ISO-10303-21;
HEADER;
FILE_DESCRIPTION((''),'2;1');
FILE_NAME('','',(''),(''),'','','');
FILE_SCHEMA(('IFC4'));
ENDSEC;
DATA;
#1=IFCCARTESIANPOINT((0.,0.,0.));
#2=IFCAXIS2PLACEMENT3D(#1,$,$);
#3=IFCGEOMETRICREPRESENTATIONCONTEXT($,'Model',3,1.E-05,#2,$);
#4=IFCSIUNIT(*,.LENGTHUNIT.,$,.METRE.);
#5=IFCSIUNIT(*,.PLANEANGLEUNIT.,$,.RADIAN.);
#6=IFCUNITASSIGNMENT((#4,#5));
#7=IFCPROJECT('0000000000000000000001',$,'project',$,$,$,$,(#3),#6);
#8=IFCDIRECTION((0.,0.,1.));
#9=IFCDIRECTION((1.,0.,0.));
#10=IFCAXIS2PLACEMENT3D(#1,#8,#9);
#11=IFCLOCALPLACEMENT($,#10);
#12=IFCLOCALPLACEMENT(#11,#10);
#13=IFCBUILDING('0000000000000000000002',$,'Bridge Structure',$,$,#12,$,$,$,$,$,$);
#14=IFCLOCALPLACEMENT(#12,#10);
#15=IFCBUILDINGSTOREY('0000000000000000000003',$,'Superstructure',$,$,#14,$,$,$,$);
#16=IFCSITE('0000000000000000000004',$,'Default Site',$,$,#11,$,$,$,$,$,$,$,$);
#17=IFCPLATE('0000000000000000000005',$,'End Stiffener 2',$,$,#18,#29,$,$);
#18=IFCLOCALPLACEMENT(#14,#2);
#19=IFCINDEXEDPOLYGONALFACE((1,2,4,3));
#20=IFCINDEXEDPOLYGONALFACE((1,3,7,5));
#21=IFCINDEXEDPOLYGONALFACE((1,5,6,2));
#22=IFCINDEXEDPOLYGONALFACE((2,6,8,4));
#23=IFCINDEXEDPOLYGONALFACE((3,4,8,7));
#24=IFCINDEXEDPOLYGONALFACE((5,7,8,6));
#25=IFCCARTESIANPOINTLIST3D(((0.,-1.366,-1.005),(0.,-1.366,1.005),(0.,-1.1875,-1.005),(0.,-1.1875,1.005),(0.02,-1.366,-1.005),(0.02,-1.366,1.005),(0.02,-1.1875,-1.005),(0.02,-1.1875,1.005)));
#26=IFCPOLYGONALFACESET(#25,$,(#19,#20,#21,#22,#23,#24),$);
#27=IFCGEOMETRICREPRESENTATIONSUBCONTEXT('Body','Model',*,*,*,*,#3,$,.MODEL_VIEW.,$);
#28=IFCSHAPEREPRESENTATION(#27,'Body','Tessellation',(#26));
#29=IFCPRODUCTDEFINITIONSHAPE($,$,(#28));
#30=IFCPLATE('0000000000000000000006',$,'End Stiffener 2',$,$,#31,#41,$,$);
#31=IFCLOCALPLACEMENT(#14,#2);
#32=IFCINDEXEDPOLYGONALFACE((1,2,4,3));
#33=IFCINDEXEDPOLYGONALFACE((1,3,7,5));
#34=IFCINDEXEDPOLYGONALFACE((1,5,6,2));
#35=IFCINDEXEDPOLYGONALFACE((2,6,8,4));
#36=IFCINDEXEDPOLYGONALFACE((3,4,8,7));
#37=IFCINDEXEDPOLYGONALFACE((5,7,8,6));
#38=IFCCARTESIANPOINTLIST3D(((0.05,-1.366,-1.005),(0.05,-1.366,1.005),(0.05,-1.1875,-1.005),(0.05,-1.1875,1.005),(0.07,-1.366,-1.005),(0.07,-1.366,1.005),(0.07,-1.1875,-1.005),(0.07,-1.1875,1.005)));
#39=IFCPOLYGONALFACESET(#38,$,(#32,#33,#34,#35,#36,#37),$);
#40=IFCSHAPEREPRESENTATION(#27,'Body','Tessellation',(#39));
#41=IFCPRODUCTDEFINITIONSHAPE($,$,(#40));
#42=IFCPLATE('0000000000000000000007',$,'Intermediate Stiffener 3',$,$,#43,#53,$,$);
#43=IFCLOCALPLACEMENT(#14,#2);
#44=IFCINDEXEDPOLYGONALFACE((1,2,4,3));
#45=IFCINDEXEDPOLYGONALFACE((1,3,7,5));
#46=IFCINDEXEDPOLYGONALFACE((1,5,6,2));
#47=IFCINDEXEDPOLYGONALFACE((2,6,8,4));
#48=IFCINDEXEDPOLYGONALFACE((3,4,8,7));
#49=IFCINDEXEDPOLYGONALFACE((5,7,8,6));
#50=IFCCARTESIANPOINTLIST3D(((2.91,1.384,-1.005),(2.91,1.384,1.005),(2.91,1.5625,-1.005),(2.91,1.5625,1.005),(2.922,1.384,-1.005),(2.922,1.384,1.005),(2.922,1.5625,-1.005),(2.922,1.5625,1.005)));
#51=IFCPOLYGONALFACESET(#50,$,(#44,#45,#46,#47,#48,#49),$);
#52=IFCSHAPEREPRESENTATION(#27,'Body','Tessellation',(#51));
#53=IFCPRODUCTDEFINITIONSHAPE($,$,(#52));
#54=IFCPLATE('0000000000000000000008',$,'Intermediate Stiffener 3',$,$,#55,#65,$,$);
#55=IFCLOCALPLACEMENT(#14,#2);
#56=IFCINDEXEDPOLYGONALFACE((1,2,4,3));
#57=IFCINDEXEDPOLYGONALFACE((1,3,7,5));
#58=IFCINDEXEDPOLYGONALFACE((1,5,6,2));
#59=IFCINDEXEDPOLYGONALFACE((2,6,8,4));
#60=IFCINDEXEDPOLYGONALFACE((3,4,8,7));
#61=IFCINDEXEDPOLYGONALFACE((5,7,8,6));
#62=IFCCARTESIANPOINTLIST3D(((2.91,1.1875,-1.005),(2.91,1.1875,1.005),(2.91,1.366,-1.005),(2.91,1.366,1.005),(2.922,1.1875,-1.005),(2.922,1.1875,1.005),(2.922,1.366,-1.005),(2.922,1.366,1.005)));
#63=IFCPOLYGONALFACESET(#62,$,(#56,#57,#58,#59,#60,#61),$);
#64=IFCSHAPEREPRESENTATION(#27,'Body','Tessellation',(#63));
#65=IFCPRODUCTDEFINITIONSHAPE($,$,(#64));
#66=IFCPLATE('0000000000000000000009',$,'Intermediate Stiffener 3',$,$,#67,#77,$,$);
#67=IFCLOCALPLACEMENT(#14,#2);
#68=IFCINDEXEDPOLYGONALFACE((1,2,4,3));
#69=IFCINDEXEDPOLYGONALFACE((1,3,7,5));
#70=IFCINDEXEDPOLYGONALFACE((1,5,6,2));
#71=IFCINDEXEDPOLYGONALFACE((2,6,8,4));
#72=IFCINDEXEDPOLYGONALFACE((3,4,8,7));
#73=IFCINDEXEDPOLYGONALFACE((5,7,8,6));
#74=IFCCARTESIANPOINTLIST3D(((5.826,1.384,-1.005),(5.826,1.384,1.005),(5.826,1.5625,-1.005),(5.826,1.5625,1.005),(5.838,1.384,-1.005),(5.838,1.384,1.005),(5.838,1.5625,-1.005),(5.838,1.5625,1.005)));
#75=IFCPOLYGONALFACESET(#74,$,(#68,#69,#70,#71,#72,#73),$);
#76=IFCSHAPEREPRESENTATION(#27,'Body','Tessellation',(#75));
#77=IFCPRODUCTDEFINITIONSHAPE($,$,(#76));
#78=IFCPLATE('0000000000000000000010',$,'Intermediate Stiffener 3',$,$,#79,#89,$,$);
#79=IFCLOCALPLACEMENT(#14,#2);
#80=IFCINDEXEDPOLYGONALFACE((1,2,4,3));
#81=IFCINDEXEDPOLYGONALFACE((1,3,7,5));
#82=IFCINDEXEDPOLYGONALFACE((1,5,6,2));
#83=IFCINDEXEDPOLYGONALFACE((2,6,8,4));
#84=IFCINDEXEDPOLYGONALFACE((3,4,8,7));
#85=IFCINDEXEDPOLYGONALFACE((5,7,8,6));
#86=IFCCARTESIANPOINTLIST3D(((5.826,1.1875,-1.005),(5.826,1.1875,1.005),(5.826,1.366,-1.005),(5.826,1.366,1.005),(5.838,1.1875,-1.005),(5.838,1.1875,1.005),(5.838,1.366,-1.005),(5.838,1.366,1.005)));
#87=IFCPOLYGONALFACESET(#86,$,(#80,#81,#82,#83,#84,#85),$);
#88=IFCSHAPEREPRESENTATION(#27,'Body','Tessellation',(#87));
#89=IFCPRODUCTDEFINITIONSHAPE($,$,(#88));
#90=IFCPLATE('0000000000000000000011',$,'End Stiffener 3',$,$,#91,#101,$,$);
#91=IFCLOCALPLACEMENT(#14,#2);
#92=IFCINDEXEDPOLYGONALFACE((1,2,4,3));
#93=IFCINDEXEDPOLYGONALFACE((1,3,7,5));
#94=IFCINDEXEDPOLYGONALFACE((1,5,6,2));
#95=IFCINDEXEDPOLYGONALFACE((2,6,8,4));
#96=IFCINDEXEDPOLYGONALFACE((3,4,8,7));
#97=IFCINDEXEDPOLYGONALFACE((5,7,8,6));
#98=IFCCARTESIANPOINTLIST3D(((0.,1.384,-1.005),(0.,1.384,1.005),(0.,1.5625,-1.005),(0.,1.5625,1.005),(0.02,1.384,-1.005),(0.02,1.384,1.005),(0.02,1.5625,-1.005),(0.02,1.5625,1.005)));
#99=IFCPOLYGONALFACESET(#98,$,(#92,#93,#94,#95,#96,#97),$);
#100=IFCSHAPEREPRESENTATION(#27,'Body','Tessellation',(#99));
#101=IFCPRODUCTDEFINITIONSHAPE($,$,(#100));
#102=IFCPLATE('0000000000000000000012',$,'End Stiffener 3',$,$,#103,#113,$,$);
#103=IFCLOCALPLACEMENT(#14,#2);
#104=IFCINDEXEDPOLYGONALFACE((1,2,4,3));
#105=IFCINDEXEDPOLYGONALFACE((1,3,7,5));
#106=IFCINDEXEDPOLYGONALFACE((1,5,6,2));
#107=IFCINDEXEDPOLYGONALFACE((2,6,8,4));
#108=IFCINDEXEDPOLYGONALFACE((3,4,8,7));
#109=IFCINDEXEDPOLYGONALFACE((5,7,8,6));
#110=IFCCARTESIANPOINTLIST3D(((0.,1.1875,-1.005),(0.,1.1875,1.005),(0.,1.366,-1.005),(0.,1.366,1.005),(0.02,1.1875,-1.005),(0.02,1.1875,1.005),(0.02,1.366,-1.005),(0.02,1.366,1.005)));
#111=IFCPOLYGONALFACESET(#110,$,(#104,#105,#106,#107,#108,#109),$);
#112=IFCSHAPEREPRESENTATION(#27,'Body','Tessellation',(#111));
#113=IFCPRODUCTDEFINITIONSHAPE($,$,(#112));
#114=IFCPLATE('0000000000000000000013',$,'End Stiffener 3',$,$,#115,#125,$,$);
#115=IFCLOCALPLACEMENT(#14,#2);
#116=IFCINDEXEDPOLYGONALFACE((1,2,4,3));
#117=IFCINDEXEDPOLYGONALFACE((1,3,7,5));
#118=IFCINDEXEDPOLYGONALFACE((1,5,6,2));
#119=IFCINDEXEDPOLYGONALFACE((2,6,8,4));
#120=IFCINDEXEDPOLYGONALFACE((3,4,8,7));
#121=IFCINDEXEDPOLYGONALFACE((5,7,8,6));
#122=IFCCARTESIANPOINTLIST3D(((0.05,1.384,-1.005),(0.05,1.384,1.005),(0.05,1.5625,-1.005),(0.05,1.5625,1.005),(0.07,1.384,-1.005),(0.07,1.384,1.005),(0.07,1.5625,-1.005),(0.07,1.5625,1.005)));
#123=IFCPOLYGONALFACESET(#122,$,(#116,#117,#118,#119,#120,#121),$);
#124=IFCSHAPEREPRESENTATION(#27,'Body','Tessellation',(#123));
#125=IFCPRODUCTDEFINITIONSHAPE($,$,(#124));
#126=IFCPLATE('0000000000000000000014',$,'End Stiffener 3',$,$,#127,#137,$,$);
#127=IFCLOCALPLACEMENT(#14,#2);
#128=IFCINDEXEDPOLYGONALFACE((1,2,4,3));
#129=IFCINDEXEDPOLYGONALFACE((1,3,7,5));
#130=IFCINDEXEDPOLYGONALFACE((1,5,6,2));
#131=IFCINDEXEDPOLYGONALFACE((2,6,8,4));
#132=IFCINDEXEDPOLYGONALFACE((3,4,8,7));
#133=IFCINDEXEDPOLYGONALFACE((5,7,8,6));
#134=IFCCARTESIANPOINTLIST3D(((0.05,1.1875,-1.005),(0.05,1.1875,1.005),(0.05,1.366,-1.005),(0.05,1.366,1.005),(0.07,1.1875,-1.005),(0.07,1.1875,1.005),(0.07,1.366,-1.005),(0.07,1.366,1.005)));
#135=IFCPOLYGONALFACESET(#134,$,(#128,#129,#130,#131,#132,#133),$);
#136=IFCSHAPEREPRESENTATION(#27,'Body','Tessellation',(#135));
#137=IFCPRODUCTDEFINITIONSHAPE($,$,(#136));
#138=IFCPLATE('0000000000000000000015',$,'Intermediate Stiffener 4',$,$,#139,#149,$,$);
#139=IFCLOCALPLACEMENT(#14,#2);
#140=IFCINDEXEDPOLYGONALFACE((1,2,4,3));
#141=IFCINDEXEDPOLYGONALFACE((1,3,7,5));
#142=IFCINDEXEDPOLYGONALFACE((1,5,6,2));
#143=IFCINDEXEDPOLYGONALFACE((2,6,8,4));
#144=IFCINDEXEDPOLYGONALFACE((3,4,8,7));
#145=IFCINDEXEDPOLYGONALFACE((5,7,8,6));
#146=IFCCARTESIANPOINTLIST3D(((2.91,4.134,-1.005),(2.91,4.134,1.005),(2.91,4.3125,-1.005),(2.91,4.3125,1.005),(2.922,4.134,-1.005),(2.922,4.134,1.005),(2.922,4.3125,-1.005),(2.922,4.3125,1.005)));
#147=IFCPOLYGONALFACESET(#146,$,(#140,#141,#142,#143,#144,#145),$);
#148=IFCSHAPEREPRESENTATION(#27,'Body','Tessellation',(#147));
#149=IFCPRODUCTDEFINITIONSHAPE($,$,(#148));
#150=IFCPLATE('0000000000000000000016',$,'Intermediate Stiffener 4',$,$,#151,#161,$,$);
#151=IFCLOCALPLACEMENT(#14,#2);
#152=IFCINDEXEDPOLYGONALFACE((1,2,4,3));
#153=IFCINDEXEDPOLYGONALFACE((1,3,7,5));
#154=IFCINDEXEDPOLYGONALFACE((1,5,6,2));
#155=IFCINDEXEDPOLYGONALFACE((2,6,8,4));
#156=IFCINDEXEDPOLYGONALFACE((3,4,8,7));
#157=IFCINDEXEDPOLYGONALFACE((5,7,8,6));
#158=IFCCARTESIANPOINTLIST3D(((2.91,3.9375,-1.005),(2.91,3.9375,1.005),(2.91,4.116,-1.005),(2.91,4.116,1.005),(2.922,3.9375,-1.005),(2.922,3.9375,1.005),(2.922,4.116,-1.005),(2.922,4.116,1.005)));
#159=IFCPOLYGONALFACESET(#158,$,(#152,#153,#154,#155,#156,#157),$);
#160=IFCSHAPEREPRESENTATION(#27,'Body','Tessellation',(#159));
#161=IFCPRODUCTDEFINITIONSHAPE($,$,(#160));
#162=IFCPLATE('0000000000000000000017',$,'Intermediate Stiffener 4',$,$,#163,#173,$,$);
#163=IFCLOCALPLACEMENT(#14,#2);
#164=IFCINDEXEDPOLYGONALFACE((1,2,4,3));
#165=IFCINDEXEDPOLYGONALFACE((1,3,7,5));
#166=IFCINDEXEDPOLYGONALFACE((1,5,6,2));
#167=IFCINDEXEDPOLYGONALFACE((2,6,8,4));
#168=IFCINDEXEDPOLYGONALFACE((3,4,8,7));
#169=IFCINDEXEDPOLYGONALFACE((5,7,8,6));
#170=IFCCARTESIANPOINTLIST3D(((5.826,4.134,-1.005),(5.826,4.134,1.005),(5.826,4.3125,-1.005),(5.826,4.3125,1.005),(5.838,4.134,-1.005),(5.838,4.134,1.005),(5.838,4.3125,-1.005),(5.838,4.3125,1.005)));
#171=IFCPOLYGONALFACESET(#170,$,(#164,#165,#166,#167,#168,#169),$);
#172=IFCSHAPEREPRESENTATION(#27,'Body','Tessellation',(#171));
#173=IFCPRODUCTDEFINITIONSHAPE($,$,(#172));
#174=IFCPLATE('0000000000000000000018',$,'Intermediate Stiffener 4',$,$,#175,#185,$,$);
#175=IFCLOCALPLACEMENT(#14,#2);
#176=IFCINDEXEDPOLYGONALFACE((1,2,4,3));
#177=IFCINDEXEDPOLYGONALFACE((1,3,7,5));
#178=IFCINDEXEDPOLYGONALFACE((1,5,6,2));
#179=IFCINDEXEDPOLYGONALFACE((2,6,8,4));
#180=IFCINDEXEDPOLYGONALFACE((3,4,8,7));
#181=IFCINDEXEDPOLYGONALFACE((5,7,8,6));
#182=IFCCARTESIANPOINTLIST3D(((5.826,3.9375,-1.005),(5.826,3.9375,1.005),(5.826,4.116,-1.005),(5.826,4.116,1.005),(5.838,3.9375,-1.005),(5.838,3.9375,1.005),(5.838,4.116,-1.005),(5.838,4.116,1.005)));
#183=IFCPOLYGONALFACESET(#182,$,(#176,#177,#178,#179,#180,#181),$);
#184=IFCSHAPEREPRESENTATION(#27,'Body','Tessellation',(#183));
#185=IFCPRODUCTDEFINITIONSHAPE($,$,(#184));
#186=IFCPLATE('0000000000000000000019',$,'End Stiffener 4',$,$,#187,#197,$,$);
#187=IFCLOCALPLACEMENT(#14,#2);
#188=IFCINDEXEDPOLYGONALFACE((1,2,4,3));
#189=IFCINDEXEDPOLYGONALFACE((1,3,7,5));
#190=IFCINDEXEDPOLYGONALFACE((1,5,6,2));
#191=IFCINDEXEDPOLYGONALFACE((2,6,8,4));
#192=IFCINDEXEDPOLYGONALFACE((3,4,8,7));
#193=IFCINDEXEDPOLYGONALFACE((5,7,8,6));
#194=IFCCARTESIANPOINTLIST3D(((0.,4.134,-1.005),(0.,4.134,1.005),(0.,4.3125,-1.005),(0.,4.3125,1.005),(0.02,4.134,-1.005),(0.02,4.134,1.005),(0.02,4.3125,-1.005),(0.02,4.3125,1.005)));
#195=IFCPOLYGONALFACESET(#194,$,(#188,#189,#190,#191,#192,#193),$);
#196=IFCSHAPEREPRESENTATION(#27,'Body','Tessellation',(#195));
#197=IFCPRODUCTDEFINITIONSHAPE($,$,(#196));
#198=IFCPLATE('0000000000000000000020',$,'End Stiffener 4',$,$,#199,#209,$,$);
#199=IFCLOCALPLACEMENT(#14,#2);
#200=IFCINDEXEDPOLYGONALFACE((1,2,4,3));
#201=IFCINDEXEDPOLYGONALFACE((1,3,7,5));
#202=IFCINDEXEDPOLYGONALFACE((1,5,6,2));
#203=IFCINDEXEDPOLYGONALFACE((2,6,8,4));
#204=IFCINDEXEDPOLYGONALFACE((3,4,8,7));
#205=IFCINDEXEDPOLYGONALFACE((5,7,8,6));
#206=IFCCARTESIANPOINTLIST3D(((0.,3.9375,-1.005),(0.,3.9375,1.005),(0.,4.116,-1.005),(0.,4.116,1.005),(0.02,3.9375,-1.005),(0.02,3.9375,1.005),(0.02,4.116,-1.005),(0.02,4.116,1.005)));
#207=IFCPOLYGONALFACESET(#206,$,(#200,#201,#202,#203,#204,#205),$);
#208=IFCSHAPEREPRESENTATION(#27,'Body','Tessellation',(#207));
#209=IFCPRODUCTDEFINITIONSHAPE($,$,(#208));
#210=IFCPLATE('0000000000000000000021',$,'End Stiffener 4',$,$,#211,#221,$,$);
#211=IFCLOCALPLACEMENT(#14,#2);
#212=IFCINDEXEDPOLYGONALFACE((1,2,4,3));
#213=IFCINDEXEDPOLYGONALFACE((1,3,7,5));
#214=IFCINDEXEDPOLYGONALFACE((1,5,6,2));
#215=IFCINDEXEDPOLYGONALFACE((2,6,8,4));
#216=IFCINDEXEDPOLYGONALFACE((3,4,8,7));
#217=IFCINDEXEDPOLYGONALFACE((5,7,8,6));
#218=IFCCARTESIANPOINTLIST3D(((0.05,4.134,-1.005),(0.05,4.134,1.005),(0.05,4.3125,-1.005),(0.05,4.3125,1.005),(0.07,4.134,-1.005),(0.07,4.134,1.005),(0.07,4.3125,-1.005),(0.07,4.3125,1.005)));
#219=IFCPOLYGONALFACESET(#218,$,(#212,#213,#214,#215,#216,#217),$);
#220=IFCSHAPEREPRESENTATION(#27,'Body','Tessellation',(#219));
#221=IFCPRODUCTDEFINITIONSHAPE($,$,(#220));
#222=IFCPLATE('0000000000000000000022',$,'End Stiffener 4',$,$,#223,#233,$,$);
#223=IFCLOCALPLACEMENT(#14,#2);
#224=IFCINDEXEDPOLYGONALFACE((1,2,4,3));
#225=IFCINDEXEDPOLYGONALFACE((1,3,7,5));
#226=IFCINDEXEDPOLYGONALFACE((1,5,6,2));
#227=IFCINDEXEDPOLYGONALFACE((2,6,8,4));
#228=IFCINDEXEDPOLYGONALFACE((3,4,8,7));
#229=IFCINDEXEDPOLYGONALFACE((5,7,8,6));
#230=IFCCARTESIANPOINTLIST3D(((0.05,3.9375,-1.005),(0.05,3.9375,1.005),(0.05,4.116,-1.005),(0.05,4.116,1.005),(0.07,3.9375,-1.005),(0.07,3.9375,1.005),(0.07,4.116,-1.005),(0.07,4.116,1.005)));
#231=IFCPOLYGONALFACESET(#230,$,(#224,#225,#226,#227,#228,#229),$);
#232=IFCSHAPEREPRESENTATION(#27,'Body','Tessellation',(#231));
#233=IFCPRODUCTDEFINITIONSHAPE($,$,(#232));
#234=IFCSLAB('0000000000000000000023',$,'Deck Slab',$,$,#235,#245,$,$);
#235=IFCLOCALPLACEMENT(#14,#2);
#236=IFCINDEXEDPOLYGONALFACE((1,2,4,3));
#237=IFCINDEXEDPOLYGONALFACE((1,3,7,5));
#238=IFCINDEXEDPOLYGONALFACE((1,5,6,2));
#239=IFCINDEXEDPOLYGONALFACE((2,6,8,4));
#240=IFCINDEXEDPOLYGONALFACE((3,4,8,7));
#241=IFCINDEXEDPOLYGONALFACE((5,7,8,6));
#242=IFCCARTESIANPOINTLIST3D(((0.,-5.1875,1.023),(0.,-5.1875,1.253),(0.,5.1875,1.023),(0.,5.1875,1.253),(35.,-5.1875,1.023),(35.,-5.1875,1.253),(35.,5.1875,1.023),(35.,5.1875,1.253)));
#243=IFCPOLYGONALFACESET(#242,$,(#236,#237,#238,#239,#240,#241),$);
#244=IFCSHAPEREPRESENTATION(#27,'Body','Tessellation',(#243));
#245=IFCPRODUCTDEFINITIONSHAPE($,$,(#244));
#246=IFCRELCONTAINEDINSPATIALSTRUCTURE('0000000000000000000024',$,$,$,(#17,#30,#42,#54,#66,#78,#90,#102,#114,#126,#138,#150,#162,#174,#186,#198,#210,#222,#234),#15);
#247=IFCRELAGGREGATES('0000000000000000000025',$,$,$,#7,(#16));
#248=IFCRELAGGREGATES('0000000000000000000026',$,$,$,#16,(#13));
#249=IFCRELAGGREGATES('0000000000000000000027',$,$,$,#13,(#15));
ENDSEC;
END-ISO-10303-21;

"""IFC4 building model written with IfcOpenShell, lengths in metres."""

from ifc_helpers import new_model, si_unit, frame, origin, origin_with_axes, origin_2d_with_axis, place, context, subcontext, project, spatial, polyline, rectangle, outline, extrude, element, save


model = new_model("IFC4")

# Units and contexts
model_context = context("Model", 3, precision=1e-05, world=origin())
body_context = subcontext(model_context, "Body", "Model", "MODEL_VIEW")
ifc_project = project(units=[si_unit("LENGTHUNIT", "METRE"), si_unit("PLANEANGLEUNIT", "RADIAN")], contexts=[model_context])

# Site, building, storey
site_placement = place(None, origin_with_axes())
site = spatial("IfcSite", under=ifc_project, at=site_placement, Name="Default Site")
building_placement = place(site_placement, origin_with_axes())
building = spatial("IfcBuilding", under=site, at=building_placement, Name="Bridge Structure")
storey_placement = place(building_placement, origin_with_axes())
storey = spatial("IfcBuildingStorey", under=building, at=storey_placement, Name="Superstructure")

# Plates
for number, where, z_axis, x_axis, name in (
    (1, (0.01, -1.2768, -1.005), (0.0, 0.0, 1.0), (1.0, 0.0, 0.0), "End Stiffener 2"),
    (2, (0.06, -1.2768, -1.005), (0.0, 0.0, 1.0), (1.0, 0.0, 0.0), "End Stiffener 2"),
):
    element("IfcPlate", number, at=place(storey_placement, frame(where, z_axis=z_axis, x_axis=x_axis)), inside=storey, Name=name, context=body_context, shape_type="SweptSolid", body=[
        extrude(rectangle(XDim=0.02, YDim=0.1785, at=origin_2d_with_axis()), origin_with_axes(), (0.0, 0.0, 1.0), 2.01),
    ])
for number, where, z_axis, x_axis, name in (
    (3, (2.916, 1.4732, -1.005), (0.0, 0.0, 1.0), (1.0, 0.0, 0.0), "Intermediate Stiffener 3"),
    (4, (2.916, 1.2768, -1.005), (0.0, 0.0, 1.0), (1.0, 0.0, 0.0), "Intermediate Stiffener 3"),
    (5, (5.832, 1.4732, -1.005), (0.0, 0.0, 1.0), (1.0, 0.0, 0.0), "Intermediate Stiffener 3"),
    (6, (5.832, 1.2768, -1.005), (0.0, 0.0, 1.0), (1.0, 0.0, 0.0), "Intermediate Stiffener 3"),
):
    element("IfcPlate", number, at=place(storey_placement, frame(where, z_axis=z_axis, x_axis=x_axis)), inside=storey, Name=name, context=body_context, shape_type="SweptSolid", body=[
        extrude(rectangle(XDim=0.012, YDim=0.1785, at=origin_2d_with_axis()), origin_with_axes(), (0.0, 0.0, 1.0), 2.01),
    ])
for number, where, z_axis, x_axis, name in (
    (7, (0.01, 1.4732, -1.005), (0.0, 0.0, 1.0), (1.0, 0.0, 0.0), "End Stiffener 3"),
    (8, (0.01, 1.2768, -1.005), (0.0, 0.0, 1.0), (1.0, 0.0, 0.0), "End Stiffener 3"),
    (9, (0.06, 1.4732, -1.005), (0.0, 0.0, 1.0), (1.0, 0.0, 0.0), "End Stiffener 3"),
    (10, (0.06, 1.2768, -1.005), (0.0, 0.0, 1.0), (1.0, 0.0, 0.0), "End Stiffener 3"),
):
    element("IfcPlate", number, at=place(storey_placement, frame(where, z_axis=z_axis, x_axis=x_axis)), inside=storey, Name=name, context=body_context, shape_type="SweptSolid", body=[
        extrude(rectangle(XDim=0.02, YDim=0.1785, at=origin_2d_with_axis()), origin_with_axes(), (0.0, 0.0, 1.0), 2.01),
    ])
for number, where, z_axis, x_axis, name in (
    (11, (2.916, 4.2233, -1.005), (0.0, 0.0, 1.0), (1.0, 0.0, 0.0), "Intermediate Stiffener 4"),
    (12, (2.916, 4.0267, -1.005), (0.0, 0.0, 1.0), (1.0, 0.0, 0.0), "Intermediate Stiffener 4"),
    (13, (5.832, 4.2233, -1.005), (0.0, 0.0, 1.0), (1.0, 0.0, 0.0), "Intermediate Stiffener 4"),
    (14, (5.832, 4.0267, -1.005), (0.0, 0.0, 1.0), (1.0, 0.0, 0.0), "Intermediate Stiffener 4"),
):
    element("IfcPlate", number, at=place(storey_placement, frame(where, z_axis=z_axis, x_axis=x_axis)), inside=storey, Name=name, context=body_context, shape_type="SweptSolid", body=[
        extrude(rectangle(XDim=0.012, YDim=0.1785, at=origin_2d_with_axis()), origin_with_axes(), (0.0, 0.0, 1.0), 2.01),
    ])
for number, where, z_axis, x_axis, name in (
    (15, (0.01, 4.2233, -1.005), (0.0, 0.0, 1.0), (1.0, 0.0, 0.0), "End Stiffener 4"),
    (16, (0.01, 4.0267, -1.005), (0.0, 0.0, 1.0), (1.0, 0.0, 0.0), "End Stiffener 4"),
    (17, (0.06, 4.2233, -1.005), (0.0, 0.0, 1.0), (1.0, 0.0, 0.0), "End Stiffener 4"),
    (18, (0.06, 4.0267, -1.005), (0.0, 0.0, 1.0), (1.0, 0.0, 0.0), "End Stiffener 4"),
):
    element("IfcPlate", number, at=place(storey_placement, frame(where, z_axis=z_axis, x_axis=x_axis)), inside=storey, Name=name, context=body_context, shape_type="SweptSolid", body=[
        extrude(rectangle(XDim=0.02, YDim=0.1785, at=origin_2d_with_axis()), origin_with_axes(), (0.0, 0.0, 1.0), 2.01),
    ])

# Slab
slab_placement = place(storey_placement, frame((0.0, 0.0, 1.023), z_axis=(0.0, 0.0, 1.0), x_axis=(1.0, 0.0, 0.0)))
element("IfcSlab", 19, at=slab_placement, inside=storey, Name="Deck Slab", context=body_context, shape_type="SweptSolid", body=[
    extrude(outline(polyline([(0.0, -5.1875), (35.0, -5.1875), (35.0, 5.1875), (0.0, 5.1875), (0.0, -5.1875)])), origin_with_axes(), (0.0, 0.0, 1.0), 0.23),
])

save(model, "model.ifc")
